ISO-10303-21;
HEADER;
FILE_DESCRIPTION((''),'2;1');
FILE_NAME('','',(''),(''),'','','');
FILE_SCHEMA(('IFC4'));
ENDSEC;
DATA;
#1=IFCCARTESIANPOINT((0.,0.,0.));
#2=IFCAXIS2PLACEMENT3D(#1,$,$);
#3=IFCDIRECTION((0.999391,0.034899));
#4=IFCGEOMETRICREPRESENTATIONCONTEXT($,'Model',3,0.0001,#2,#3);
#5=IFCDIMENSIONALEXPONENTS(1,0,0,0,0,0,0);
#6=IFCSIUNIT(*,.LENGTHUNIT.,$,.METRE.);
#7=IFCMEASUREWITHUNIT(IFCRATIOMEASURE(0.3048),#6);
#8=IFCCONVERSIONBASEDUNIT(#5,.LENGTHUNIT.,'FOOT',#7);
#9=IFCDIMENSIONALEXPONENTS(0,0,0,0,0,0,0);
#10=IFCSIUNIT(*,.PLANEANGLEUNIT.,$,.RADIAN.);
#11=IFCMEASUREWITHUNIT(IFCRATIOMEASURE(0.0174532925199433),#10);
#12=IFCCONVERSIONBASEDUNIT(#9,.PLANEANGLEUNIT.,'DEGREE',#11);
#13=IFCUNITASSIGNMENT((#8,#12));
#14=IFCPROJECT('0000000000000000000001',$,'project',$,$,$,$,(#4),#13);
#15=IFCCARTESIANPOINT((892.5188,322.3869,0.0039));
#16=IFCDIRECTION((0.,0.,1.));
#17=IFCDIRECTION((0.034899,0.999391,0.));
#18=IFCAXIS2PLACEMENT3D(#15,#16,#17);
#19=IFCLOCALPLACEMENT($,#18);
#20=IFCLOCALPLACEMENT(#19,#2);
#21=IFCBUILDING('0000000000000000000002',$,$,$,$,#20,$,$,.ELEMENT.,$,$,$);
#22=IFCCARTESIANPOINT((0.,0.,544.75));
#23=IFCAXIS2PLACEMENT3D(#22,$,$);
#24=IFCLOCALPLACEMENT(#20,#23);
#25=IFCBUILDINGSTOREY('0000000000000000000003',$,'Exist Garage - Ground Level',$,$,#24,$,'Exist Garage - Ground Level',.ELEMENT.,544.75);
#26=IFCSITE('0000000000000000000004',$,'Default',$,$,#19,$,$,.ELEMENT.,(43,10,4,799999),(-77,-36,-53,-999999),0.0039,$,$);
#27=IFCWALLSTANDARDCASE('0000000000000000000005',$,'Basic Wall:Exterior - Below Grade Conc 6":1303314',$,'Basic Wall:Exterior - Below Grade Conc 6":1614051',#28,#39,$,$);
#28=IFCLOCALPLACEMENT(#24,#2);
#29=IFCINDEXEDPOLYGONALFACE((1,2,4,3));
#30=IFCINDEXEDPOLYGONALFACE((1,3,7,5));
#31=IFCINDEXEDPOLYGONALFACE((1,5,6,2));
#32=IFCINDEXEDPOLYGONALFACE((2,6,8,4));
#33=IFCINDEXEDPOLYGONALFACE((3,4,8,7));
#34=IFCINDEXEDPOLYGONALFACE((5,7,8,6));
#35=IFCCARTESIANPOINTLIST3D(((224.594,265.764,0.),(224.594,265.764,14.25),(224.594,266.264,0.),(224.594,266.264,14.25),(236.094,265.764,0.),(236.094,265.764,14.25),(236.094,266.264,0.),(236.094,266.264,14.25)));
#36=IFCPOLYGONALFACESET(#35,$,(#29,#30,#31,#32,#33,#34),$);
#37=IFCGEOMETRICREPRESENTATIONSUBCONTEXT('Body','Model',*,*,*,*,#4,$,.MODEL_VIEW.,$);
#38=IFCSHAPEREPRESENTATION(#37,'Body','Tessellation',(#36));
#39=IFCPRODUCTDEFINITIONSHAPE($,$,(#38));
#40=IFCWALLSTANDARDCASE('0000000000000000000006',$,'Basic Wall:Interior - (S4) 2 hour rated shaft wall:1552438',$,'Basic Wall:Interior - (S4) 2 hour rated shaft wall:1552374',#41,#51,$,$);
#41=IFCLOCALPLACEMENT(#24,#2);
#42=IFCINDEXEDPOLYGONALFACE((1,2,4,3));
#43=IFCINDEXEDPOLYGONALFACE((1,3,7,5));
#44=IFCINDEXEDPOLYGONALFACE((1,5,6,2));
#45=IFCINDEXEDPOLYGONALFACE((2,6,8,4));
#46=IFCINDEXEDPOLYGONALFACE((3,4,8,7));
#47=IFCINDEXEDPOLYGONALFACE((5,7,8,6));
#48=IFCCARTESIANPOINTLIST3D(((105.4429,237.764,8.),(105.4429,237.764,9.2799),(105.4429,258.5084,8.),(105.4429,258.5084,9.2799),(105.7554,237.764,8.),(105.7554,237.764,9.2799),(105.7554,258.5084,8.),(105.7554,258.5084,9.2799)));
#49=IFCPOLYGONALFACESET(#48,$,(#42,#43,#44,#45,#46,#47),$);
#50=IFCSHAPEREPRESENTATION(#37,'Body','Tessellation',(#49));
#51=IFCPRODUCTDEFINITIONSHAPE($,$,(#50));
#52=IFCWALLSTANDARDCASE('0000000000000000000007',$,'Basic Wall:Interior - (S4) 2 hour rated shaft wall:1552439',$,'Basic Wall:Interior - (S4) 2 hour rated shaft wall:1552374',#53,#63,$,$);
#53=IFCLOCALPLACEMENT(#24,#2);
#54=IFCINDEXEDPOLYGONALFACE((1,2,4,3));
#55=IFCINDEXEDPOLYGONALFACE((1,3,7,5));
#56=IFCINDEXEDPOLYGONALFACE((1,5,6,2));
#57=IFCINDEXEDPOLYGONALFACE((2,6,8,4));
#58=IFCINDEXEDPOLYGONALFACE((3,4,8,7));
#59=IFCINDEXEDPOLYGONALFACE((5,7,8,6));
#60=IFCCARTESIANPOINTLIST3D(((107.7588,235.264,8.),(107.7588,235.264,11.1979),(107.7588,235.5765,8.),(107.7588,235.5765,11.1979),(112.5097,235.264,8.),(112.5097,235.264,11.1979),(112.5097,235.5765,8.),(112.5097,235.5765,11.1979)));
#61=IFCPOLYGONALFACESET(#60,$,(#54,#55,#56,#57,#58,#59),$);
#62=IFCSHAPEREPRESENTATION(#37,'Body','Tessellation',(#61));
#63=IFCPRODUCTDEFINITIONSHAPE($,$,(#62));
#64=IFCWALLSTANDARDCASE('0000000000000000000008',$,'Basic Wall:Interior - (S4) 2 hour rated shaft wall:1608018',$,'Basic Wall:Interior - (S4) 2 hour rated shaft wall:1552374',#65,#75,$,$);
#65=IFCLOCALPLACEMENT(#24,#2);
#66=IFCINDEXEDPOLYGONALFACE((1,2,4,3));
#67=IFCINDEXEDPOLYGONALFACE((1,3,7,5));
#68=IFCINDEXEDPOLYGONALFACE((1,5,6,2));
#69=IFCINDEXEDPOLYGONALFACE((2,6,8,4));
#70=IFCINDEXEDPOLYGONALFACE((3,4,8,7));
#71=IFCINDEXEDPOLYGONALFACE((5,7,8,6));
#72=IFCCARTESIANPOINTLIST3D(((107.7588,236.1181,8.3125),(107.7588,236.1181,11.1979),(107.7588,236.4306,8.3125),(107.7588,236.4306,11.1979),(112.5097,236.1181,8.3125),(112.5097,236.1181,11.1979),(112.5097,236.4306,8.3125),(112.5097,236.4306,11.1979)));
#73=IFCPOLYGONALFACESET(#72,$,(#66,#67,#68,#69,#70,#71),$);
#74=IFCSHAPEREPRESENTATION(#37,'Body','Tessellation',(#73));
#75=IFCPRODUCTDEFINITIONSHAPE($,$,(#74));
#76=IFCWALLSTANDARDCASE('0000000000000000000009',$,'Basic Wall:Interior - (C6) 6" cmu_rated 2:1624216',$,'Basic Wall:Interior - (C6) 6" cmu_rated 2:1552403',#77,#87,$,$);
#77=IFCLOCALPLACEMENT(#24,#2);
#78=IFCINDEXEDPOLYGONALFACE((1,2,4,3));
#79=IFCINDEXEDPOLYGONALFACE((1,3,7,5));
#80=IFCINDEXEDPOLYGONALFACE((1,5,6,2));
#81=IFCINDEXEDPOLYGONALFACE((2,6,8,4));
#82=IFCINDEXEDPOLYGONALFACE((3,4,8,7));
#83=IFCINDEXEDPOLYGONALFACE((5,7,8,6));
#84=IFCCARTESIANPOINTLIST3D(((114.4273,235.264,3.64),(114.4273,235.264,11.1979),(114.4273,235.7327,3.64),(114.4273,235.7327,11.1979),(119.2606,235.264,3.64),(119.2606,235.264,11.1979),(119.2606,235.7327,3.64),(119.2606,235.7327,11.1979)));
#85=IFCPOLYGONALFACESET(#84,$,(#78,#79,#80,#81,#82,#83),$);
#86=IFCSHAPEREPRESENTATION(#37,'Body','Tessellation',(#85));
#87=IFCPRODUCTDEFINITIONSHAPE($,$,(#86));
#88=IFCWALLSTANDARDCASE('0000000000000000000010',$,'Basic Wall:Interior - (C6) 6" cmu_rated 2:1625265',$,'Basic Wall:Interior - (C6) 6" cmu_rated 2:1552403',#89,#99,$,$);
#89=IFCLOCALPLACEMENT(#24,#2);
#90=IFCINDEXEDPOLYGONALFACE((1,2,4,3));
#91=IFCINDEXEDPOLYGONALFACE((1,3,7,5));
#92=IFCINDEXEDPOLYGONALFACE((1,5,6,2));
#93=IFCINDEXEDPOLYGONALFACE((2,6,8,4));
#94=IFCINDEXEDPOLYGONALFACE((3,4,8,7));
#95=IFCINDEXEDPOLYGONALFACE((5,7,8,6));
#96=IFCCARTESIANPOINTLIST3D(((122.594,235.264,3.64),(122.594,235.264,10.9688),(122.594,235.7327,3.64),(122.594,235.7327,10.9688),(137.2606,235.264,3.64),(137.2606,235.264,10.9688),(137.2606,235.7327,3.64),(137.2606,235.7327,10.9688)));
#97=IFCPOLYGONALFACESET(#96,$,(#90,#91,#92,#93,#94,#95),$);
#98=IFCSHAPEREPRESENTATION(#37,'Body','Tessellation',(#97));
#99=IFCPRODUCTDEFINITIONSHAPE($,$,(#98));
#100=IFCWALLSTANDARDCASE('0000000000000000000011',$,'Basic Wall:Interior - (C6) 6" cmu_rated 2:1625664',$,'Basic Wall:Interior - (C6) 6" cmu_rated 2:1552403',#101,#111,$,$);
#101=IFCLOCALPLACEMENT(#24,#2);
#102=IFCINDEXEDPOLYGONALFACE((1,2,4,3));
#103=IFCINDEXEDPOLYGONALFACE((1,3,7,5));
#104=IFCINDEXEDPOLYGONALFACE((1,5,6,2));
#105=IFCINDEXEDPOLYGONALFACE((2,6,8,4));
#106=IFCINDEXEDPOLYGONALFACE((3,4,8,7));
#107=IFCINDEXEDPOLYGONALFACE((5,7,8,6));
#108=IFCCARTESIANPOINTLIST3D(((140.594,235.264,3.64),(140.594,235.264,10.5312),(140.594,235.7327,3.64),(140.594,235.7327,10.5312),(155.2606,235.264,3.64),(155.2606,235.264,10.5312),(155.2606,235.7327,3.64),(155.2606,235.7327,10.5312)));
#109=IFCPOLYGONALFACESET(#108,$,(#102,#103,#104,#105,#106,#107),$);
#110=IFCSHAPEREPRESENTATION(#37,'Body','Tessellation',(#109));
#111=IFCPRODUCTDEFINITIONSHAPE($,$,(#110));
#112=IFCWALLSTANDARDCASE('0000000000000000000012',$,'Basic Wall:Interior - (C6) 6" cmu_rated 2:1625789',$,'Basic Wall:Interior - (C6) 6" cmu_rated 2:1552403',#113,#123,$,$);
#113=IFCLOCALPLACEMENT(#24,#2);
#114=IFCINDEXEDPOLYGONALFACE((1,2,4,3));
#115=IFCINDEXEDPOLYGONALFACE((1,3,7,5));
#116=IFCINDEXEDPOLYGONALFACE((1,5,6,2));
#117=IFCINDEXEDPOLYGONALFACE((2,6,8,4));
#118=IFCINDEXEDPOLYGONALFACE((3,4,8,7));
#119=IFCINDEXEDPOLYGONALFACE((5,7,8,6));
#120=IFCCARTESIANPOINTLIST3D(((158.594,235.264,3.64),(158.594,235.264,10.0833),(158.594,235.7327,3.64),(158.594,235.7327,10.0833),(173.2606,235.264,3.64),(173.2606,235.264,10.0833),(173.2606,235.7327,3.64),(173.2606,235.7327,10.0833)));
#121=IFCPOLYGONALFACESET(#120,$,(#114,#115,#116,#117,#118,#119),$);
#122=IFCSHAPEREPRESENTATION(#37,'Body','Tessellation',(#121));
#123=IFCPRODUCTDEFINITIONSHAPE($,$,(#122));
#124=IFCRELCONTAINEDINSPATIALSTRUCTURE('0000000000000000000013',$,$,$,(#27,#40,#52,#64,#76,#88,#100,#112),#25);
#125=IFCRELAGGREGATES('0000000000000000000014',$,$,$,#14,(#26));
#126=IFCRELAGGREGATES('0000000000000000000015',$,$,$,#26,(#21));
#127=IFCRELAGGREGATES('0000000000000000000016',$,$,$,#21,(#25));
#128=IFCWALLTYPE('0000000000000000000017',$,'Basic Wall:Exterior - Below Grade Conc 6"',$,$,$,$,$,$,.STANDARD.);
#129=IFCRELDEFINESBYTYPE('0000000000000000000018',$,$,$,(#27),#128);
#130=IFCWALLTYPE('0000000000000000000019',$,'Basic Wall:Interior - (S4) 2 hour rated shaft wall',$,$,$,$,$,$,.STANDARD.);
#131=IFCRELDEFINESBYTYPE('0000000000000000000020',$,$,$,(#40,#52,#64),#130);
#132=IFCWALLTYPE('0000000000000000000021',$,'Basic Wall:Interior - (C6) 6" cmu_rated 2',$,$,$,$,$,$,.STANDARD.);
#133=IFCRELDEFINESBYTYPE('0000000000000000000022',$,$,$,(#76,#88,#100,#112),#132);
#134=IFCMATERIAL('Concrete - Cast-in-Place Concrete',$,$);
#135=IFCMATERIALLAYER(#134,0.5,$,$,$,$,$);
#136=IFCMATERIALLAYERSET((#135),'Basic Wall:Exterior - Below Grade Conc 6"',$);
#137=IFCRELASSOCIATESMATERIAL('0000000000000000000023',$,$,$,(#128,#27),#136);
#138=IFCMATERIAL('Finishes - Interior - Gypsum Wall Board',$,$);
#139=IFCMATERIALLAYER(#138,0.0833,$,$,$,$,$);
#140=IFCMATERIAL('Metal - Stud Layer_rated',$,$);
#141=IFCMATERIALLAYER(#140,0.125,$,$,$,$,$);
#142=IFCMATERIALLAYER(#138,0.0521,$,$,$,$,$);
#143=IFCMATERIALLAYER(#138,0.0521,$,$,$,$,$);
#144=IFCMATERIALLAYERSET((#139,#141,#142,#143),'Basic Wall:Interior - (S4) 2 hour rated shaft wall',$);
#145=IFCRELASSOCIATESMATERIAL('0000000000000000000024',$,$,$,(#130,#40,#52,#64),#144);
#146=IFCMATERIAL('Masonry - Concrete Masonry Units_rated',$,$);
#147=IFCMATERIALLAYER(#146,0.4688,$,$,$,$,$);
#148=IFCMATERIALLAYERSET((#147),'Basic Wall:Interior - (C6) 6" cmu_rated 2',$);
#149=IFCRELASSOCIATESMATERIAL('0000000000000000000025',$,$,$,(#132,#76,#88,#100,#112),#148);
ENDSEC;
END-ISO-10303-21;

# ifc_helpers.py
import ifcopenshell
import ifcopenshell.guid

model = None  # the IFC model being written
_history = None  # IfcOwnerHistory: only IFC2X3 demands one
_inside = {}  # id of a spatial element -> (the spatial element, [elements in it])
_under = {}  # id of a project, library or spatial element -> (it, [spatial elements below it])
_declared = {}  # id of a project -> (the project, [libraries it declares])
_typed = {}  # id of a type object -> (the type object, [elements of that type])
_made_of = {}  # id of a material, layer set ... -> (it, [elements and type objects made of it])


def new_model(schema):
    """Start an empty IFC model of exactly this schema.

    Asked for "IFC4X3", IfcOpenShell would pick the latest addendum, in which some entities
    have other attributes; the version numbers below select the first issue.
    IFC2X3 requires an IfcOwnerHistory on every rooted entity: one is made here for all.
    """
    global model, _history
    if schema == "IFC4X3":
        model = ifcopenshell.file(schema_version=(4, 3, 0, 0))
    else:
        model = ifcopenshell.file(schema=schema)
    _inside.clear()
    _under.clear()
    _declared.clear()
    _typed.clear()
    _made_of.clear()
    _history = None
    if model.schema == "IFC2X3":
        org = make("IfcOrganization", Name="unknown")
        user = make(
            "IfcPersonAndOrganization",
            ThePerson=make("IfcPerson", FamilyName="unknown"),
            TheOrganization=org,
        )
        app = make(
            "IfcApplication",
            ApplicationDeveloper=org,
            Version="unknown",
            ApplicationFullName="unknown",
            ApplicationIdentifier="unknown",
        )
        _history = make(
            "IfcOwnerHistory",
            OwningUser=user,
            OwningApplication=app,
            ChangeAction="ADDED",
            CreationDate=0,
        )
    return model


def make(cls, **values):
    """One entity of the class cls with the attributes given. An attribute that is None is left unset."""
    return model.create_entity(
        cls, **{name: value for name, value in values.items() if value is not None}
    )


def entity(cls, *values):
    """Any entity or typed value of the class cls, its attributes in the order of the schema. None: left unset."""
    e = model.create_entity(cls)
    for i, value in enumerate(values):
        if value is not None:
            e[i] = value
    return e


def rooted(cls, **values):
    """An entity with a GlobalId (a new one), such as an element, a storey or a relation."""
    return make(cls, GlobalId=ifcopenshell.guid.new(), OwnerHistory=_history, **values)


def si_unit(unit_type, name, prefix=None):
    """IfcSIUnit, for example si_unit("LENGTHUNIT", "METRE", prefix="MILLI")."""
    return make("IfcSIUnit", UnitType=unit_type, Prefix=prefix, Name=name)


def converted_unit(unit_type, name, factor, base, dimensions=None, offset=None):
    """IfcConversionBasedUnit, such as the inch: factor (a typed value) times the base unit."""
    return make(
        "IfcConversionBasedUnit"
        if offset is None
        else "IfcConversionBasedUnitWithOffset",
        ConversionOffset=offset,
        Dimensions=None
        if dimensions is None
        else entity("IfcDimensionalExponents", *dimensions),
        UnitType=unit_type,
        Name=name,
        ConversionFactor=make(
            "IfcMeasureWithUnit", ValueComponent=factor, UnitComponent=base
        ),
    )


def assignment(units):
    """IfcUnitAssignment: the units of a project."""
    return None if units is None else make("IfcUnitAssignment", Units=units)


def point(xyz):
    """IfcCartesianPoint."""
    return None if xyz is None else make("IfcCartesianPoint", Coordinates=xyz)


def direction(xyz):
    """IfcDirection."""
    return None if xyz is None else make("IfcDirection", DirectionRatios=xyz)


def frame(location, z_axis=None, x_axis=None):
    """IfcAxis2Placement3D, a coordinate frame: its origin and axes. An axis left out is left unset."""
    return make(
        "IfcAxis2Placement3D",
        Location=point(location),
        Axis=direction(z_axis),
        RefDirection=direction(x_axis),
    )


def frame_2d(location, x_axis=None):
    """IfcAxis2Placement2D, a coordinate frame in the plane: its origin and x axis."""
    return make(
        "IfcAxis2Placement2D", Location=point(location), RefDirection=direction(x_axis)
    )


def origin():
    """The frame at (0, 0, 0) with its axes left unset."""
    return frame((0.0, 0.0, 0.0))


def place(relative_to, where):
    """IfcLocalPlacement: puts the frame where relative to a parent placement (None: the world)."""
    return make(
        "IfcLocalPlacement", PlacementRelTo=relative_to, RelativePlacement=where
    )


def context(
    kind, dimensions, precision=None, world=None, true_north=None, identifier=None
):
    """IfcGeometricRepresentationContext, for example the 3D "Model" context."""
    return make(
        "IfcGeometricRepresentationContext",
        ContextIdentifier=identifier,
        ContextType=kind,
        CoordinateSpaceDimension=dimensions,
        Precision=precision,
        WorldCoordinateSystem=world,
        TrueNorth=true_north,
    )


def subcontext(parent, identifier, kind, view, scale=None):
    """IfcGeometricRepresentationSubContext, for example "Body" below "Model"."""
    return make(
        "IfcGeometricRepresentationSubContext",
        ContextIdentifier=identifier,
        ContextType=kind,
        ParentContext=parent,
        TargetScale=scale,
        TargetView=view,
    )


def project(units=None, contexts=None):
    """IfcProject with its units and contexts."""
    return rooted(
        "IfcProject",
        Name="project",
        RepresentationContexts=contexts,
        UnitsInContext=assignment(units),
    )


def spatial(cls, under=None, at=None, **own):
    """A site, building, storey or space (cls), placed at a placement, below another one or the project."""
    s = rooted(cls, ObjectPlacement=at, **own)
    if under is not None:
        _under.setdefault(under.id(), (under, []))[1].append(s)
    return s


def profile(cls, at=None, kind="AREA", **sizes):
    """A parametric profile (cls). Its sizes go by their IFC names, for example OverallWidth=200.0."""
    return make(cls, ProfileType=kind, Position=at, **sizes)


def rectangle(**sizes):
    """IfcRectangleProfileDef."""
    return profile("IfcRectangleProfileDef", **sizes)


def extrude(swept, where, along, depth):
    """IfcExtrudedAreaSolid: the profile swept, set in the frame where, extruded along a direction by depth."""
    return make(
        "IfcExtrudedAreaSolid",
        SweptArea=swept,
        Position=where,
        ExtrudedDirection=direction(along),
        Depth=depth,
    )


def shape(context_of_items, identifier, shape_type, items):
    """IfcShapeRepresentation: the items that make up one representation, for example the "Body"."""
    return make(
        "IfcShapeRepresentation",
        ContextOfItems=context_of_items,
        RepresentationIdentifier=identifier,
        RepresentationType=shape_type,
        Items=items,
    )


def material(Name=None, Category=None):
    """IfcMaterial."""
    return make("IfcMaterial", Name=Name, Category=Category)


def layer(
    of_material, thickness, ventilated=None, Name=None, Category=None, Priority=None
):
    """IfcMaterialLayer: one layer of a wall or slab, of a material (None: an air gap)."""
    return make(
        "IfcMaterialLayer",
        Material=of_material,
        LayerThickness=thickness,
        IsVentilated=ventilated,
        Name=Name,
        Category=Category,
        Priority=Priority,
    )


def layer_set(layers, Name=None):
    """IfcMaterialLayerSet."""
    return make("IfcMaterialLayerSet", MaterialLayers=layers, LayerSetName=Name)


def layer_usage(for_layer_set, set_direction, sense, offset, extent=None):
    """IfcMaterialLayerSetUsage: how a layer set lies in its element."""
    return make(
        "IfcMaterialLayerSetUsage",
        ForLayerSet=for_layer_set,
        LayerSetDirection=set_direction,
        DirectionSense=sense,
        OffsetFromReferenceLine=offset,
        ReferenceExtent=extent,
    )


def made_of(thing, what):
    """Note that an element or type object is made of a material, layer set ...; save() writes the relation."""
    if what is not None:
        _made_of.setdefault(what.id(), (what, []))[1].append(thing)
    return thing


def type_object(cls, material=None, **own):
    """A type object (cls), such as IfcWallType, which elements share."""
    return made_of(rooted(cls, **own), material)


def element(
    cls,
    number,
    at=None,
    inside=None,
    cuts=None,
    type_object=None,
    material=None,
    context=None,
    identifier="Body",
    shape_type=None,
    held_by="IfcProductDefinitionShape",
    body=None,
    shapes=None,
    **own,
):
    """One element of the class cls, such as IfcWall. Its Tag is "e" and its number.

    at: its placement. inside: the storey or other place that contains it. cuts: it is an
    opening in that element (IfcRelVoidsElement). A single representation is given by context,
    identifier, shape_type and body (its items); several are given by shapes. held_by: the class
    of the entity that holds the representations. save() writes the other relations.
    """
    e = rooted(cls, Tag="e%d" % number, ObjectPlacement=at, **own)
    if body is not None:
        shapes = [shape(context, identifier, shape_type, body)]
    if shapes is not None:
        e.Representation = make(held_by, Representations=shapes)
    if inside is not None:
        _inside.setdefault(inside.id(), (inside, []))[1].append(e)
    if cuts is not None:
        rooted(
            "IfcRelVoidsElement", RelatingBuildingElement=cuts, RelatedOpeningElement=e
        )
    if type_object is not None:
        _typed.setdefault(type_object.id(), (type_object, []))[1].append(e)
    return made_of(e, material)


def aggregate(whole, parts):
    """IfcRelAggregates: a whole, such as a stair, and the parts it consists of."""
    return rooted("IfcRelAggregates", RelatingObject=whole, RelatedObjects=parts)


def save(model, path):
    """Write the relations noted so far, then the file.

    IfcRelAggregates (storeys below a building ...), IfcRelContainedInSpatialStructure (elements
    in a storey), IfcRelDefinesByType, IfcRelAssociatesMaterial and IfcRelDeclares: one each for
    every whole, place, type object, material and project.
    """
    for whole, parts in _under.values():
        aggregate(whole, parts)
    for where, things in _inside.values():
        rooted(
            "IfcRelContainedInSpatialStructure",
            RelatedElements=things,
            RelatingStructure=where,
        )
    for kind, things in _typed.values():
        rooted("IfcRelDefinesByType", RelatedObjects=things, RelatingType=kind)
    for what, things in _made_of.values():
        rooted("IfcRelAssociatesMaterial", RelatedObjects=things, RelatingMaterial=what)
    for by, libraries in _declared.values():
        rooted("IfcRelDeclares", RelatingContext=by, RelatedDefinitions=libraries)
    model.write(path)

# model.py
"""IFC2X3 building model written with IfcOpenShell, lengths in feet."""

from ifc_helpers import new_model, entity, si_unit, converted_unit, direction, frame, frame_2d, origin, place, context, subcontext, project, spatial, rectangle, extrude, material, layer, layer_set, layer_usage, type_object, element, save


model = new_model("IFC2X3")

# Units and contexts
model_context = context("Model", 3, precision=0.0001, world=origin(), true_north=direction((0.999391, 0.034899)))
body_context = subcontext(model_context, "Body", "Model", "MODEL_VIEW")
ifc_project = project(units=[converted_unit("LENGTHUNIT", "FOOT", entity("IfcRatioMeasure", 0.3048), si_unit("LENGTHUNIT", "METRE"), dimensions=[1, 0, 0, 0, 0, 0, 0]), converted_unit("PLANEANGLEUNIT", "DEGREE", entity("IfcRatioMeasure", 0.0174532925199433), si_unit("PLANEANGLEUNIT", "RADIAN"), dimensions=[0, 0, 0, 0, 0, 0, 0])], contexts=[model_context])

# Site, building, storey
site_placement = place(None, frame((892.5188, 322.3869, 0.0039), z_axis=(0.0, 0.0, 1.0), x_axis=(0.034899, 0.999391, 0.0)))
site = spatial("IfcSite", under=ifc_project, at=site_placement, Name="Default", CompositionType="ELEMENT", RefLatitude=(43, 10, 4, 799999), RefLongitude=(-77, -36, -53, -999999), RefElevation=0.0039)
building_placement = place(site_placement, origin())
building = spatial("IfcBuilding", under=site, at=building_placement, CompositionType="ELEMENT")
storey_placement = place(building_placement, frame((0.0, 0.0, 544.75)))
storey = spatial("IfcBuildingStorey", under=building, at=storey_placement, Name="Exist Garage - Ground Level", LongName="Exist Garage - Ground Level", CompositionType="ELEMENT", Elevation=544.75)

# Walls
ifc_material_1 = material(Name="Concrete - Cast-in-Place Concrete")
ifc_layer_1 = layer(ifc_material_1, 0.5)
ifc_layer_set_1 = layer_set([ifc_layer_1], Name="Basic Wall:Exterior - Below Grade Conc 6\"")
ifc_layer_usage_1 = layer_usage(ifc_layer_set_1, "AXIS2", "POSITIVE", -0.25)
wall_type_1 = type_object("IfcWallType", Name="Basic Wall:Exterior - Below Grade Conc 6\"", PredefinedType="STANDARD", material=ifc_layer_set_1)
wall_1_placement = place(storey_placement, frame((236.094, 266.014, 0.0), z_axis=(0.0, 0.0, 1.0), x_axis=(-1.0, 0.0, 0.0)))
element("IfcWallStandardCase", 1, at=wall_1_placement, inside=storey, type_object=wall_type_1, material=ifc_layer_usage_1, Name="Basic Wall:Exterior - Below Grade Conc 6\":1303314", ObjectType="Basic Wall:Exterior - Below Grade Conc 6\":1614051", context=body_context, shape_type="SweptSolid", body=[
    extrude(rectangle(XDim=11.5, YDim=0.5, at=frame_2d((5.75, 0.0), x_axis=(-1.0, 0.0))), origin(), (0.0, 0.0, 1.0), 14.25),
])
ifc_material_2 = material(Name="Finishes - Interior - Gypsum Wall Board")
ifc_layer_2 = layer(ifc_material_2, 0.0833)
ifc_material_3 = material(Name="Metal - Stud Layer_rated")
ifc_layer_3 = layer(ifc_material_3, 0.125)
ifc_layer_4 = layer(ifc_material_2, 0.0521)
ifc_layer_5 = layer(ifc_material_2, 0.0521)
ifc_layer_set_2 = layer_set([ifc_layer_2, ifc_layer_3, ifc_layer_4, ifc_layer_5], Name="Basic Wall:Interior - (S4) 2 hour rated shaft wall")
ifc_layer_usage_2 = layer_usage(ifc_layer_set_2, "AXIS2", "NEGATIVE", 0.1562)
wall_type_2 = type_object("IfcWallType", Name="Basic Wall:Interior - (S4) 2 hour rated shaft wall", PredefinedType="STANDARD", material=ifc_layer_set_2)
wall_2_placement = place(storey_placement, frame((105.5992, 258.5084, 8.0), z_axis=(0.0, 0.0, 1.0), x_axis=(0.0, -1.0, 0.0)))
element("IfcWallStandardCase", 2, at=wall_2_placement, inside=storey, type_object=wall_type_2, material=ifc_layer_usage_2, Name="Basic Wall:Interior - (S4) 2 hour rated shaft wall:1552438", ObjectType="Basic Wall:Interior - (S4) 2 hour rated shaft wall:1552374", context=body_context, shape_type="SweptSolid", body=[
    extrude(rectangle(XDim=20.7445, YDim=0.3125, at=frame_2d((10.3722, 0.0), x_axis=(-1.0, 0.0))), origin(), (0.0, 0.0, 1.0), 1.2799),
])
ifc_layer_usage_3 = layer_usage(ifc_layer_set_2, "AXIS2", "NEGATIVE", 0.1562)
wall_3_placement = place(storey_placement, frame((107.7588, 235.4202, 8.0)))
element("IfcWallStandardCase", 3, at=wall_3_placement, inside=storey, type_object=wall_type_2, material=ifc_layer_usage_3, Name="Basic Wall:Interior - (S4) 2 hour rated shaft wall:1552439", ObjectType="Basic Wall:Interior - (S4) 2 hour rated shaft wall:1552374", context=body_context, shape_type="SweptSolid", body=[
    extrude(rectangle(XDim=4.7509, YDim=0.3125, at=frame_2d((2.3755, 0.0), x_axis=(-1.0, 0.0))), origin(), (0.0, 0.0, 1.0), 3.1979),
])
ifc_layer_usage_4 = layer_usage(ifc_layer_set_2, "AXIS2", "POSITIVE", -0.1562)
wall_4_placement = place(storey_placement, frame((107.7588, 236.2744, 8.3125)))
element("IfcWallStandardCase", 4, at=wall_4_placement, inside=storey, type_object=wall_type_2, material=ifc_layer_usage_4, Name="Basic Wall:Interior - (S4) 2 hour rated shaft wall:1608018", ObjectType="Basic Wall:Interior - (S4) 2 hour rated shaft wall:1552374", context=body_context, shape_type="SweptSolid", body=[
    extrude(rectangle(XDim=4.7509, YDim=0.3125, at=frame_2d((2.3755, 0.0), x_axis=(-1.0, 0.0))), origin(), (0.0, 0.0, 1.0), 2.8854),
])
ifc_material_4 = material(Name="Masonry - Concrete Masonry Units_rated")
ifc_layer_6 = layer(ifc_material_4, 0.4688)
ifc_layer_set_3 = layer_set([ifc_layer_6], Name="Basic Wall:Interior - (C6) 6\" cmu_rated 2")
ifc_layer_usage_5 = layer_usage(ifc_layer_set_3, "AXIS2", "POSITIVE", -0.2344)
wall_type_3 = type_object("IfcWallType", Name="Basic Wall:Interior - (C6) 6\" cmu_rated 2", PredefinedType="STANDARD", material=ifc_layer_set_3)
wall_5_placement = place(storey_placement, frame((114.4273, 235.4983, 3.64)))
element("IfcWallStandardCase", 5, at=wall_5_placement, inside=storey, type_object=wall_type_3, material=ifc_layer_usage_5, Name="Basic Wall:Interior - (C6) 6\" cmu_rated 2:1624216", ObjectType="Basic Wall:Interior - (C6) 6\" cmu_rated 2:1552403", context=body_context, shape_type="SweptSolid", body=[
    extrude(rectangle(XDim=4.8333, YDim=0.4688, at=frame_2d((2.4167, 0.0), x_axis=(-1.0, 0.0))), origin(), (0.0, 0.0, 1.0), 7.5579),
])
ifc_layer_usage_6 = layer_usage(ifc_layer_set_3, "AXIS2", "POSITIVE", -0.2344)
wall_6_placement = place(storey_placement, frame((122.594, 235.4983, 3.64)))
element("IfcWallStandardCase", 6, at=wall_6_placement, inside=storey, type_object=wall_type_3, material=ifc_layer_usage_6, Name="Basic Wall:Interior - (C6) 6\" cmu_rated 2:1625265", ObjectType="Basic Wall:Interior - (C6) 6\" cmu_rated 2:1552403", context=body_context, shape_type="SweptSolid", body=[
    extrude(rectangle(XDim=14.6667, YDim=0.4688, at=frame_2d((7.3333, 0.0), x_axis=(-1.0, 0.0))), origin(), (0.0, 0.0, 1.0), 7.3287),
])
ifc_layer_usage_7 = layer_usage(ifc_layer_set_3, "AXIS2", "POSITIVE", -0.2344)
wall_7_placement = place(storey_placement, frame((140.594, 235.4983, 3.64)))
element("IfcWallStandardCase", 7, at=wall_7_placement, inside=storey, type_object=wall_type_3, material=ifc_layer_usage_7, Name="Basic Wall:Interior - (C6) 6\" cmu_rated 2:1625664", ObjectType="Basic Wall:Interior - (C6) 6\" cmu_rated 2:1552403", context=body_context, shape_type="SweptSolid", body=[
    extrude(rectangle(XDim=14.6667, YDim=0.4688, at=frame_2d((7.3333, 0.0), x_axis=(-1.0, 0.0))), origin(), (0.0, 0.0, 1.0), 6.8912),
])
ifc_layer_usage_8 = layer_usage(ifc_layer_set_3, "AXIS2", "POSITIVE", -0.2344)
wall_8_placement = place(storey_placement, frame((158.594, 235.4983, 3.64)))
element("IfcWallStandardCase", 8, at=wall_8_placement, inside=storey, type_object=wall_type_3, material=ifc_layer_usage_8, Name="Basic Wall:Interior - (C6) 6\" cmu_rated 2:1625789", ObjectType="Basic Wall:Interior - (C6) 6\" cmu_rated 2:1552403", context=body_context, shape_type="SweptSolid", body=[
    extrude(rectangle(XDim=14.6667, YDim=0.4688, at=frame_2d((7.3333, 0.0), x_axis=(-1.0, 0.0))), origin(), (0.0, 0.0, 1.0), 6.4433),
])

save(model, "model.ifc")
